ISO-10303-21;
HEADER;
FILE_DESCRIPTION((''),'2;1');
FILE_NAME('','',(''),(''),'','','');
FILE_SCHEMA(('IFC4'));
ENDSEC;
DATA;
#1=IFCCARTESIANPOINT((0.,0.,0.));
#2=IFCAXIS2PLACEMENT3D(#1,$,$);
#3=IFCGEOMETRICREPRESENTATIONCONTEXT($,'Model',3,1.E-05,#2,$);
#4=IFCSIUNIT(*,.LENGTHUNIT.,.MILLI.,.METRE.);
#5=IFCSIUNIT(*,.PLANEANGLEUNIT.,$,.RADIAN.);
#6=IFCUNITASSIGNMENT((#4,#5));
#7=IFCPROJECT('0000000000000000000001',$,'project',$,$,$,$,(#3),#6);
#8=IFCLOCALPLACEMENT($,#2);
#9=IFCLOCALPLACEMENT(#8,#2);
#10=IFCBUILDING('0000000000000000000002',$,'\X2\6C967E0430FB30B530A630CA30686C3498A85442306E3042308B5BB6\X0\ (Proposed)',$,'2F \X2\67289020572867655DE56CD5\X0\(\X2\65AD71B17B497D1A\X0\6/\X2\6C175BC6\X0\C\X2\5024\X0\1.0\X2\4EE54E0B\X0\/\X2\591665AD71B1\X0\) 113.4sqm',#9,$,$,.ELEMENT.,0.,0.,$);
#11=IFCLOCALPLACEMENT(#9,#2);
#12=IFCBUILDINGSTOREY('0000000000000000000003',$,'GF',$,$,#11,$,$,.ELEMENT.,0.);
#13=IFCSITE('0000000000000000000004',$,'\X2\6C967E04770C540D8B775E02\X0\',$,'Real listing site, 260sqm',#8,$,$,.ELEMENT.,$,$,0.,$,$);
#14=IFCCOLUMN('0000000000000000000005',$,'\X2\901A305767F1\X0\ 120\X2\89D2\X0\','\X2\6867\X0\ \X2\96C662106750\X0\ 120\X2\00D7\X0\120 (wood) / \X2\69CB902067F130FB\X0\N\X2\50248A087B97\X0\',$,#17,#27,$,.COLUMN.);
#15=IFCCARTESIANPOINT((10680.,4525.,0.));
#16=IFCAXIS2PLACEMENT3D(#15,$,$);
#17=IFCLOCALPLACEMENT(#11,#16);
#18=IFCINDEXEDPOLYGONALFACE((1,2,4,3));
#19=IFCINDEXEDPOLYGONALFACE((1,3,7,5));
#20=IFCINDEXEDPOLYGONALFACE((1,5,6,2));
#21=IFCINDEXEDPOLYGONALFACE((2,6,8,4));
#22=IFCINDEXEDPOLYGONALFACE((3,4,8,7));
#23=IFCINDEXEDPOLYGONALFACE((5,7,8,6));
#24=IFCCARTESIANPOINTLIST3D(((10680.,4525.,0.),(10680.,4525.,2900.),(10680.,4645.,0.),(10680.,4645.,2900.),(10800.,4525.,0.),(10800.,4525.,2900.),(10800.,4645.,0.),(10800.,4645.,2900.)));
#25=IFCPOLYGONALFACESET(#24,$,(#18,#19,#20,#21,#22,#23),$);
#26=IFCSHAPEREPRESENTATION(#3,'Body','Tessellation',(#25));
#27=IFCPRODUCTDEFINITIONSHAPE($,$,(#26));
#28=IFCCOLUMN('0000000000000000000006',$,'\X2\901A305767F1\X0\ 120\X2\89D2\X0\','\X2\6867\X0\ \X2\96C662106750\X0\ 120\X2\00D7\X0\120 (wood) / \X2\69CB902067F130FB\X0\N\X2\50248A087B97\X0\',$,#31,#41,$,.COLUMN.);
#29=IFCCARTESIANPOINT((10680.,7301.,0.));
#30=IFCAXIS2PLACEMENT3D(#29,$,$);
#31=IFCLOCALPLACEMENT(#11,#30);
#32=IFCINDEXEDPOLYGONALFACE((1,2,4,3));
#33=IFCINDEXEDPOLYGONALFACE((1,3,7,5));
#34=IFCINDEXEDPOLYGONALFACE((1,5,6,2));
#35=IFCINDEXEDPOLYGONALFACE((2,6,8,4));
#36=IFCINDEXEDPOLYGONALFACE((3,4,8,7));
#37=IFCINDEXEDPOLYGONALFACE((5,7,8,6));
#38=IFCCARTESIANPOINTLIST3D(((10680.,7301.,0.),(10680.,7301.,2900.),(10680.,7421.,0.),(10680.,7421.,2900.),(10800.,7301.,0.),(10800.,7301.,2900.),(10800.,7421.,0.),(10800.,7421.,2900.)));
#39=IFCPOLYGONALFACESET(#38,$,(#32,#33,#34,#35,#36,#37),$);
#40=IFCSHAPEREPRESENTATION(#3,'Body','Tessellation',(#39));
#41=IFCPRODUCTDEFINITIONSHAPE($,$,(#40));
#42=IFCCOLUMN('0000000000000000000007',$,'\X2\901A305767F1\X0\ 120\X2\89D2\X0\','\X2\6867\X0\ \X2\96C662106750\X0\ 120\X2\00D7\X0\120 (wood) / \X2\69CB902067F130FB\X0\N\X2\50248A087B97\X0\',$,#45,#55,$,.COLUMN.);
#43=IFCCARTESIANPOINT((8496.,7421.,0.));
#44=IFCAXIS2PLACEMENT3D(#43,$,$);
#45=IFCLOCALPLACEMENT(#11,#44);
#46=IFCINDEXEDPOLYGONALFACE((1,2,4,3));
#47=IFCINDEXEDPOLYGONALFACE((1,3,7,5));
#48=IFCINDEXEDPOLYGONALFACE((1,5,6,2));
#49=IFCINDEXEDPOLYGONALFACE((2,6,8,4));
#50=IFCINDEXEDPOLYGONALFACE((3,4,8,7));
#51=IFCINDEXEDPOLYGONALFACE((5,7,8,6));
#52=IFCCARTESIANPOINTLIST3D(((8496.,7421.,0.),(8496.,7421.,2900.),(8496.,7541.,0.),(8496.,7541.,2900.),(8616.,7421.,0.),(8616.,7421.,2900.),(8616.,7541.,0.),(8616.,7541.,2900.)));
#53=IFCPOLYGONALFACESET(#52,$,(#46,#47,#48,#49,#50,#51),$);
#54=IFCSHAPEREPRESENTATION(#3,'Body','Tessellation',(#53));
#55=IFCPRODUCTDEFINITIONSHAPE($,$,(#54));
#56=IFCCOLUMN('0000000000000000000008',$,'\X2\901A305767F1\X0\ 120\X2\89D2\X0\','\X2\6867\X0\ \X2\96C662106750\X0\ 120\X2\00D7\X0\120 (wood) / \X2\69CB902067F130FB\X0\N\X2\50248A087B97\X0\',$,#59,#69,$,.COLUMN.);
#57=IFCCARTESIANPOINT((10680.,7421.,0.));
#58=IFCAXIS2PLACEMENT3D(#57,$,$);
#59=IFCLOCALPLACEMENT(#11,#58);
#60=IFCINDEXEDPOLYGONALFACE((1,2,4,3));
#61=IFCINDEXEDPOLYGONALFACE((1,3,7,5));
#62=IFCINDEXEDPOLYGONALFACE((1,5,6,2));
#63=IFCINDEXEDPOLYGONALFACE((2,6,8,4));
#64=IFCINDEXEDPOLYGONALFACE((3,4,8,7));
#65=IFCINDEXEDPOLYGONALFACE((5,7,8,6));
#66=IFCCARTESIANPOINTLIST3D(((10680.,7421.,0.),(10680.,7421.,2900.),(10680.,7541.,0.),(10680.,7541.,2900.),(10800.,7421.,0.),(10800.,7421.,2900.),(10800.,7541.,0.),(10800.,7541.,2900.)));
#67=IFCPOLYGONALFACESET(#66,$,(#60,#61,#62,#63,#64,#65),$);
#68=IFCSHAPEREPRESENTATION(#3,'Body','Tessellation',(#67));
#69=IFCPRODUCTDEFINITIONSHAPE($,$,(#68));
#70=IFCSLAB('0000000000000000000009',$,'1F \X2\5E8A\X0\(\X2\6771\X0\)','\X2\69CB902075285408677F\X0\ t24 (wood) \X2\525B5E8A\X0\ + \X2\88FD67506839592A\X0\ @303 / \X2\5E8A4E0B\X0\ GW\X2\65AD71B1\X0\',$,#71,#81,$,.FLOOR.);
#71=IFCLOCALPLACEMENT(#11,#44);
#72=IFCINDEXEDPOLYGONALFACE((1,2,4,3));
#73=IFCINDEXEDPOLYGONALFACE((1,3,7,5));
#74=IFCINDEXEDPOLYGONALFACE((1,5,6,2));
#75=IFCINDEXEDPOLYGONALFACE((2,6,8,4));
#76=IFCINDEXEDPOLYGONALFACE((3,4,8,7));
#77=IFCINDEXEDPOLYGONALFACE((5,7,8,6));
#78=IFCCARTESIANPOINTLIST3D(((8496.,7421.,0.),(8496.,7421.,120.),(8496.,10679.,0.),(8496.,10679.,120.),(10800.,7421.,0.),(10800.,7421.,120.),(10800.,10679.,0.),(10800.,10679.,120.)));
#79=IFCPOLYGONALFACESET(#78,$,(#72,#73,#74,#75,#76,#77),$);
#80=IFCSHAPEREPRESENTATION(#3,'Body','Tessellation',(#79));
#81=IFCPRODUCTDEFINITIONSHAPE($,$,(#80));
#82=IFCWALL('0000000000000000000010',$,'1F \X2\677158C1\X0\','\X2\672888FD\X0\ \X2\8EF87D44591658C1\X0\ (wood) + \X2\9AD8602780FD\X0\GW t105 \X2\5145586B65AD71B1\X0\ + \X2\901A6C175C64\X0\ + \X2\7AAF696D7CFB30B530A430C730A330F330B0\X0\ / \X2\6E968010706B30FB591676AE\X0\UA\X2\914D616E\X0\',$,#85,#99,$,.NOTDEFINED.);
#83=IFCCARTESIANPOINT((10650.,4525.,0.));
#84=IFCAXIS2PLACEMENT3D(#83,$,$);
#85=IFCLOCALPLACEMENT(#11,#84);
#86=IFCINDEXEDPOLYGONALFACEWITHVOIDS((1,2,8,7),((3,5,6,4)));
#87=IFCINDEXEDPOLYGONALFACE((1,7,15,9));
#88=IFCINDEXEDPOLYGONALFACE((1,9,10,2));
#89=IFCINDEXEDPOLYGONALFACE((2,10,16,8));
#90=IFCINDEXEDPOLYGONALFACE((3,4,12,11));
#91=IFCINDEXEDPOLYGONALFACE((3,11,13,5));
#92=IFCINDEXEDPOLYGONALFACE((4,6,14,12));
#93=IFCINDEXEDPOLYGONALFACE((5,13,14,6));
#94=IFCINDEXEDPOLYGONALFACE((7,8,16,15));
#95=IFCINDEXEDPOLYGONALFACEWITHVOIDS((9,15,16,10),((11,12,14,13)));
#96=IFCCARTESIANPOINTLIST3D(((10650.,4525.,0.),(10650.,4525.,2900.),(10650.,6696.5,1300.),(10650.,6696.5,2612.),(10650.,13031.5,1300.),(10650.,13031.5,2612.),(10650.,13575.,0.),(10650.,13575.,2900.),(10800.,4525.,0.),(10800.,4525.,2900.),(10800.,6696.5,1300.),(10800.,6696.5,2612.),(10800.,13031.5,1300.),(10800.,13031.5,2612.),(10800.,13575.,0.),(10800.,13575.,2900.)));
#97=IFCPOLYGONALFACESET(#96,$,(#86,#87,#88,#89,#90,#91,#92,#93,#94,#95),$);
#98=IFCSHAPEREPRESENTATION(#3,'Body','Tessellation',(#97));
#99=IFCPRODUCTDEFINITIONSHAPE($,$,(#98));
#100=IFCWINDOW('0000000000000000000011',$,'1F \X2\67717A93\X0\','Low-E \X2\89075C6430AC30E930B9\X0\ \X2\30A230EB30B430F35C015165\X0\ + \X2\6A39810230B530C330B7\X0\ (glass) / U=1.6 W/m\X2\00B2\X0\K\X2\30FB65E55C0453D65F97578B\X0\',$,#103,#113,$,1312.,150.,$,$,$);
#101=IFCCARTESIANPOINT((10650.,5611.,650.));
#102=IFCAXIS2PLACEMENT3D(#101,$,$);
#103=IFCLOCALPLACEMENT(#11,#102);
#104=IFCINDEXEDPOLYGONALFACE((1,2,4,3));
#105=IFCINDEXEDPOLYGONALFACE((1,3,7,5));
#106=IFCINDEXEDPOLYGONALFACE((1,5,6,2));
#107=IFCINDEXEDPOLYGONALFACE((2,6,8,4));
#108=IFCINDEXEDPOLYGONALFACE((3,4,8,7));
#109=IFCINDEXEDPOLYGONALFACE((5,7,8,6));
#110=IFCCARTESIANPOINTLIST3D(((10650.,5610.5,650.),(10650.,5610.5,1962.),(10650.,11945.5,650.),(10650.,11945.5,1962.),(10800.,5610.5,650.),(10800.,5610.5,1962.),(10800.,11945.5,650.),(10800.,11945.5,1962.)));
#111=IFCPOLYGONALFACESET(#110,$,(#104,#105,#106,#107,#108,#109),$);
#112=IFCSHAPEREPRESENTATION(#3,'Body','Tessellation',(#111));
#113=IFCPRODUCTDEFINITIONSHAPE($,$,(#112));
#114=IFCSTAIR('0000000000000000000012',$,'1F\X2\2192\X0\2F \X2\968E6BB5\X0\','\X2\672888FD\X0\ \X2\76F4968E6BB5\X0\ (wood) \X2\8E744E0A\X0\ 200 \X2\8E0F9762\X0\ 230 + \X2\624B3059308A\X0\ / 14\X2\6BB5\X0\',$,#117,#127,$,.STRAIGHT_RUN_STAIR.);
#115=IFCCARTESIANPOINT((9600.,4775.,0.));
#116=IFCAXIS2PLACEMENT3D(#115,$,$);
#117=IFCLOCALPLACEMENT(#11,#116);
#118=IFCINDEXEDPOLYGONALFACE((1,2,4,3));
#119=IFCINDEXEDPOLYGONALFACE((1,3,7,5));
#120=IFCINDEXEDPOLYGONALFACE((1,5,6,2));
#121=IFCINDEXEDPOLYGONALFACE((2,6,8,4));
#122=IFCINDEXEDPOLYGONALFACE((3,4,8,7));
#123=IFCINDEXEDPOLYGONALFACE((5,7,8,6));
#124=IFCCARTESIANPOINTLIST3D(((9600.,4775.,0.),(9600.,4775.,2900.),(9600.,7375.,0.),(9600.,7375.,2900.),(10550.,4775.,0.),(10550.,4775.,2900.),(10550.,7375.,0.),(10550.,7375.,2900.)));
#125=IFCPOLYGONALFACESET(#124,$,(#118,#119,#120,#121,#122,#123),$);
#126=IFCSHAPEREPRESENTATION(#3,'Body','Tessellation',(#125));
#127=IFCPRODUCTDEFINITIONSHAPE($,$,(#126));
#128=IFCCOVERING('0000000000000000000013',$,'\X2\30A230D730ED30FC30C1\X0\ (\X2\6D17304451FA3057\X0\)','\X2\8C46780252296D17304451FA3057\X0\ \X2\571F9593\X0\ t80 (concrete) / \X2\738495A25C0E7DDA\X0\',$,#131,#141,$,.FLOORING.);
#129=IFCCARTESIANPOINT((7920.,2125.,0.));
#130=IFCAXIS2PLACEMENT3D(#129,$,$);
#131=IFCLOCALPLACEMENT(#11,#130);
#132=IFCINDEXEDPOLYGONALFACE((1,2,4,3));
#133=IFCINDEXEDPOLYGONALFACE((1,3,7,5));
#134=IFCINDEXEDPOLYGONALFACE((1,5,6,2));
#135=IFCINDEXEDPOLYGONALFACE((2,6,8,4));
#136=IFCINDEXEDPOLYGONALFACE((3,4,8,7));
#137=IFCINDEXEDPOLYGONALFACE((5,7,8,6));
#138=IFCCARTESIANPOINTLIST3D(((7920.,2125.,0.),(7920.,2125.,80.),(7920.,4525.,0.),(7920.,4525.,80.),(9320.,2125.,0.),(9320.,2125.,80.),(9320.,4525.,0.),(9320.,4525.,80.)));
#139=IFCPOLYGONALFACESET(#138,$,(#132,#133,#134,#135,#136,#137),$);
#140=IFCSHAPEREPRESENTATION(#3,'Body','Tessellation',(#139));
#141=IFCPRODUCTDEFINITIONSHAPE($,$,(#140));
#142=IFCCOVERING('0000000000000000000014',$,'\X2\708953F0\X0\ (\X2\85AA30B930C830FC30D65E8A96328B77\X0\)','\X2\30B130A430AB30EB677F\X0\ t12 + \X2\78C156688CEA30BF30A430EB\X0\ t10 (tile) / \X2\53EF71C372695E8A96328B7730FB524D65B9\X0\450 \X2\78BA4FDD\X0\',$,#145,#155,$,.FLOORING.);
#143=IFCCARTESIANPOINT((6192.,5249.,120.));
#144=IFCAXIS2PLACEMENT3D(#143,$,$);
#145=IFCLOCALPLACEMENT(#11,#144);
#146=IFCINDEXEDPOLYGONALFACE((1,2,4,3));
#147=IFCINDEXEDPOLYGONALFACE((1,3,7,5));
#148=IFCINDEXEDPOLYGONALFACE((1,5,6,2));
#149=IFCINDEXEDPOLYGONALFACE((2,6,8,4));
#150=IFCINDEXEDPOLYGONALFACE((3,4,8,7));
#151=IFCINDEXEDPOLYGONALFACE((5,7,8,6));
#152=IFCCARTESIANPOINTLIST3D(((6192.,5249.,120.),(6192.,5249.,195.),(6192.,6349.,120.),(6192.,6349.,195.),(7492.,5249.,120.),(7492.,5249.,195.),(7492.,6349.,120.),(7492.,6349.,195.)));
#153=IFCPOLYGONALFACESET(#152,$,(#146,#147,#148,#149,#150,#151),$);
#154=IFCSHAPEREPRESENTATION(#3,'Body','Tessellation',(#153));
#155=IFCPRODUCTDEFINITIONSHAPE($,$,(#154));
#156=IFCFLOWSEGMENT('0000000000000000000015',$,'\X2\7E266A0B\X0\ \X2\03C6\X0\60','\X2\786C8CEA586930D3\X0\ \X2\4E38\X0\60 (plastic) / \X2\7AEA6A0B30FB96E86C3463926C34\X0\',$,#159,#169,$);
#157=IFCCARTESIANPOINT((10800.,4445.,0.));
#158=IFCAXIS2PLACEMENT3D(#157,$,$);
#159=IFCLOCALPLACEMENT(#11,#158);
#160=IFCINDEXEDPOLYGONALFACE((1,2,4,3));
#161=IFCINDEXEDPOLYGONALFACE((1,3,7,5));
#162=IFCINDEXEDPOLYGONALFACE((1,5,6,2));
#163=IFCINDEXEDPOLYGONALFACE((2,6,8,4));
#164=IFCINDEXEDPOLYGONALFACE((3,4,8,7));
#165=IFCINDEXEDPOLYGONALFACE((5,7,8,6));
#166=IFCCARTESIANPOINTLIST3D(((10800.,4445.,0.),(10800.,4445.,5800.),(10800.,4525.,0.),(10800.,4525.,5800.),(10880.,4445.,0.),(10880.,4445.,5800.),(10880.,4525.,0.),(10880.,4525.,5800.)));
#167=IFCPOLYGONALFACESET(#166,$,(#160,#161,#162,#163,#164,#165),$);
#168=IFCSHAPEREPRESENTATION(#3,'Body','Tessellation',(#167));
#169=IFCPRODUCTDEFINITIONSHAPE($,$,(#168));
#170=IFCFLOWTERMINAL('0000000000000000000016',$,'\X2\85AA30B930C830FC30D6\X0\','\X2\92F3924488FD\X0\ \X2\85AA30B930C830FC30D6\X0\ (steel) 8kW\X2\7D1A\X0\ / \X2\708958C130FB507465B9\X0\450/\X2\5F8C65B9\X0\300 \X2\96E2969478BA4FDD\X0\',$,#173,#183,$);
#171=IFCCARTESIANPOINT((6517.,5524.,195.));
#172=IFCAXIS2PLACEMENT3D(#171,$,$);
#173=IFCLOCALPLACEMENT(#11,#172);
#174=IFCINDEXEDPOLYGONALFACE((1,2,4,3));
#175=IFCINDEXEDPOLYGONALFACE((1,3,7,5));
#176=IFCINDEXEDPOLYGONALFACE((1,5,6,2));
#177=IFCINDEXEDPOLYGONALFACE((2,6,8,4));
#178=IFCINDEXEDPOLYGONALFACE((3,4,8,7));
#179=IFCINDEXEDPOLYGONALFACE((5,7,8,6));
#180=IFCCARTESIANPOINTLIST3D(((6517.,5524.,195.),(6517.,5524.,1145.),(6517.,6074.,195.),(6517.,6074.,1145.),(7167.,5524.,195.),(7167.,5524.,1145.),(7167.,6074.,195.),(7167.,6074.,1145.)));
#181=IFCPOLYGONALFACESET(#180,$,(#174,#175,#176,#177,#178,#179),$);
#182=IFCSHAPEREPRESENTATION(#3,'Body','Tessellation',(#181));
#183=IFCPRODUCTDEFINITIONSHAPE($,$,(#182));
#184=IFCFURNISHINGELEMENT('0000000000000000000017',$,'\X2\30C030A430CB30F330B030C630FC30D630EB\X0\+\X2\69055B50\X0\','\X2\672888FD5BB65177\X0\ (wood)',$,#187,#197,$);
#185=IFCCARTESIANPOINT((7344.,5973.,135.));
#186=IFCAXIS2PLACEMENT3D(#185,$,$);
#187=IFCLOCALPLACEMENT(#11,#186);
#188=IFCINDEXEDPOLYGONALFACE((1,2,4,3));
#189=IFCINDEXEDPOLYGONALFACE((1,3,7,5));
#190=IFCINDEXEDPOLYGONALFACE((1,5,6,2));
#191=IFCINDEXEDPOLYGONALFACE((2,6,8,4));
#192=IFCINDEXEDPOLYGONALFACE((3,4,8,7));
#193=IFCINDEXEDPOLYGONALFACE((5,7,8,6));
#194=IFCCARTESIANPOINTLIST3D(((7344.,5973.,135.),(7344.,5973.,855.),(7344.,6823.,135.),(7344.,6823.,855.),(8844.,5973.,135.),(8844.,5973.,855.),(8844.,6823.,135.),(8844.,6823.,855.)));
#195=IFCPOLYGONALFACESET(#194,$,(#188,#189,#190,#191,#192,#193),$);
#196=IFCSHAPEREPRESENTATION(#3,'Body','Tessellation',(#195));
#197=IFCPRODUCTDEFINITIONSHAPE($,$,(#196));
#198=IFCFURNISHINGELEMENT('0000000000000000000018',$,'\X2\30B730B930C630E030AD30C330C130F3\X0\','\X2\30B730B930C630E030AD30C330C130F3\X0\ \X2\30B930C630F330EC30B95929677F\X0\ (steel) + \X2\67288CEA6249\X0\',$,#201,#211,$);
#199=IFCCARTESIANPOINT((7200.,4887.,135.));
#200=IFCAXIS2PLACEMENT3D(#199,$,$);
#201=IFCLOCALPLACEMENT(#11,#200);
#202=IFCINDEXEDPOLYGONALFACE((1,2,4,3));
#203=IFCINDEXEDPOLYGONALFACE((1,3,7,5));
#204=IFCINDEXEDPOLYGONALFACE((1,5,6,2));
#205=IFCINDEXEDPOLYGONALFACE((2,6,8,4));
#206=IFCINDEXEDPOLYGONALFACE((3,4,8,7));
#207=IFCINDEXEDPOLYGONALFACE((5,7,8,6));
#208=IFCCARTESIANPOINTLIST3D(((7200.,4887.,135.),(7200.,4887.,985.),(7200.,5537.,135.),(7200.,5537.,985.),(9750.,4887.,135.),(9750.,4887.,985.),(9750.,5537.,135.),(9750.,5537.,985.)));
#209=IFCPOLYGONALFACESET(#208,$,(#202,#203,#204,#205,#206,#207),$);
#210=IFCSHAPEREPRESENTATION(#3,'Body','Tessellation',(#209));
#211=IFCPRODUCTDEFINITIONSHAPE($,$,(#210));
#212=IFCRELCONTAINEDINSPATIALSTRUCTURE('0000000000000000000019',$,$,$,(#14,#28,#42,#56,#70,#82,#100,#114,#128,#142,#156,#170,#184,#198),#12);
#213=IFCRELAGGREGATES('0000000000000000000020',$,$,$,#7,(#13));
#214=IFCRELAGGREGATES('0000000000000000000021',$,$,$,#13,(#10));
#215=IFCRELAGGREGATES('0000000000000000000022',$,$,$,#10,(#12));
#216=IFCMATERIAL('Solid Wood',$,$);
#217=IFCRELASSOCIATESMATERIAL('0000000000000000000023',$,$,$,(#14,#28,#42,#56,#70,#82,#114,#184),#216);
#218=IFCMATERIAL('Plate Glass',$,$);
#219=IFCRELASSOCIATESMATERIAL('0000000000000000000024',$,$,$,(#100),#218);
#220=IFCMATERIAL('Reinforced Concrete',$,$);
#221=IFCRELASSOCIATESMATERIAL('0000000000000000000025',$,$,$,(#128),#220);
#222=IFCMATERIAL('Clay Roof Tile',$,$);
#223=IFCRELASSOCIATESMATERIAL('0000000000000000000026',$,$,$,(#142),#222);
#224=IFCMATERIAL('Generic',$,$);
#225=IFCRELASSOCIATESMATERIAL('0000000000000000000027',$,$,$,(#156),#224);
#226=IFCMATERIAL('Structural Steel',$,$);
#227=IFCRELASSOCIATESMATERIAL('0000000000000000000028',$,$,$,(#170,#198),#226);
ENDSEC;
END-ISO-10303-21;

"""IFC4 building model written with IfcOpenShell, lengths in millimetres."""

from ifc_helpers import new_model, si_unit, frame, frame_2d, origin, place, context, project, spatial, rectangle, extrude, material, element, fill, save


model = new_model("IFC4")

# Units and contexts
model_context = context("Model", 3, precision=1e-05, world=origin())
ifc_project = project(units=[si_unit("LENGTHUNIT", "METRE", prefix="MILLI"), si_unit("PLANEANGLEUNIT", "RADIAN")], contexts=[model_context])

# Site, building, storey
site_placement = place(None, origin())
site = spatial("IfcSite", under=ifc_project, at=site_placement, Name="沖縄県名護市", ObjectType="Real listing site, 260sqm", CompositionType="ELEMENT", RefElevation=0.0)
building_placement = place(site_placement, origin())
building = spatial("IfcBuilding", under=site, at=building_placement, Name="沖縄・サウナと水風呂のある家 (Proposed)", ObjectType="2F 木造在来工法(断熱等級6/気密C値1.0以下/外断熱) 113.4sqm", CompositionType="ELEMENT", ElevationOfRefHeight=0.0, ElevationOfTerrain=0.0)
storey_placement = place(building_placement, origin())
storey = spatial("IfcBuildingStorey", under=building, at=storey_placement, Name="GF", CompositionType="ELEMENT", Elevation=0.0)

# Columns
ifc_material_1 = material(Name="Solid Wood")
column_1_placement = place(storey_placement, frame((10680.0, 4525.0, 0.0)))
element("IfcColumn", 1, at=column_1_placement, inside=storey, material=ifc_material_1, Name="通し柱 120角", Description="桧 集成材 120×120 (wood) / 構造柱・N値計算", PredefinedType="COLUMN", context=model_context, shape_type="SweptSolid", body=[
    extrude(rectangle(XDim=120.0, YDim=120.0, at=frame_2d((60.0, 60.0))), frame((10680.0, 4525.0, 0.0)), (0.0, 0.0, 1.0), 2900.0),
])
column_2_placement = place(storey_placement, frame((10680.0, 7301.0, 0.0)))
element("IfcColumn", 2, at=column_2_placement, inside=storey, material=ifc_material_1, Name="通し柱 120角", Description="桧 集成材 120×120 (wood) / 構造柱・N値計算", PredefinedType="COLUMN", context=model_context, shape_type="SweptSolid", body=[
    extrude(rectangle(XDim=120.0, YDim=120.0, at=frame_2d((60.0, 60.0))), frame((10680.0, 7301.0, 0.0)), (0.0, 0.0, 1.0), 2900.0),
])
column_3_placement = place(storey_placement, frame((8496.0, 7421.0, 0.0)))
element("IfcColumn", 3, at=column_3_placement, inside=storey, material=ifc_material_1, Name="通し柱 120角", Description="桧 集成材 120×120 (wood) / 構造柱・N値計算", PredefinedType="COLUMN", context=model_context, shape_type="SweptSolid", body=[
    extrude(rectangle(XDim=120.0, YDim=120.0, at=frame_2d((60.0, 60.0))), frame((8496.0, 7421.0, 0.0)), (0.0, 0.0, 1.0), 2900.0),
])
column_4_placement = place(storey_placement, frame((10680.0, 7421.0, 0.0)))
element("IfcColumn", 4, at=column_4_placement, inside=storey, material=ifc_material_1, Name="通し柱 120角", Description="桧 集成材 120×120 (wood) / 構造柱・N値計算", PredefinedType="COLUMN", context=model_context, shape_type="SweptSolid", body=[
    extrude(rectangle(XDim=120.0, YDim=120.0, at=frame_2d((60.0, 60.0))), frame((10680.0, 7421.0, 0.0)), (0.0, 0.0, 1.0), 2900.0),
])

# Slab
slab_placement = place(storey_placement, frame((8496.0, 7421.0, 0.0)))
element("IfcSlab", 5, at=slab_placement, inside=storey, material=ifc_material_1, Name="1F 床(東)", Description="構造用合板 t24 (wood) 剛床 + 製材根太 @303 / 床下 GW断熱", PredefinedType="FLOOR", context=model_context, shape_type="SweptSolid", body=[
    extrude(rectangle(XDim=2304.0, YDim=3258.0, at=frame_2d((1152.0, 1629.0))), frame((8496.0, 7421.0, 0.0)), (0.0, 0.0, 1.0), 120.0),
])

# Wall, opening, window
wall_1_placement = place(storey_placement, frame((10650.0, 4525.0, 0.0)))
wall_1 = element("IfcWall", 6, at=wall_1_placement, inside=storey, material=ifc_material_1, Name="1F 東壁", Description="木製 軸組外壁 (wood) + 高性能GW t105 充填断熱 + 通気層 + 窯業系サイディング / 準耐火・外皮UA配慮", PredefinedType="NOTDEFINED", context=model_context, shape_type="SweptSolid", body=[
    extrude(rectangle(XDim=150.0, YDim=9050.0, at=frame_2d((75.0, 4525.0))), frame((10650.0, 4525.0, 0.0)), (0.0, 0.0, 1.0), 2900.0),
])
opening_placement = place(storey_placement, frame((10650.0, 5611.0, 650.0)))
opening = element("IfcOpeningElement", 7, at=opening_placement, cuts=wall_1, PredefinedType="NOTDEFINED", context=model_context, shape_type="SweptSolid", body=[
    extrude(rectangle(XDim=150.0, YDim=6335.0, at=frame_2d((75.0, 3167.0))), frame((10650.0, 5611.0, 650.0)), (0.0, 0.0, 1.0), 1312.0),
])
ifc_material_2 = material(Name="Plate Glass")
window_placement = place(storey_placement, frame((10650.0, 5611.0, 650.0)))
window = element("IfcWindow", 8, at=window_placement, inside=storey, material=ifc_material_2, Name="1F 東窓", Description="Low-E 複層ガラス アルゴン封入 + 樹脂サッシ (glass) / U=1.6 W/m²K・日射取得型", OverallHeight=1312.0, OverallWidth=150.0, context=model_context, shape_type="SweptSolid", body=[
    extrude(rectangle(XDim=150.0, YDim=6335.0, at=frame_2d((75.0, 3167.0))), frame((10650.0, 5611.0, 650.0)), (0.0, 0.0, 1.0), 1312.0),
])
fill(opening, window)

# Stair
stair_placement = place(storey_placement, frame((9600.0, 4775.0, 0.0)))
element("IfcStair", 9, at=stair_placement, inside=storey, material=ifc_material_1, Name="1F→2F 階段", Description="木製 直階段 (wood) 蹴上 200 踏面 230 + 手すり / 14段", PredefinedType="STRAIGHT_RUN_STAIR", context=model_context, shape_type="SweptSolid", body=[
    extrude(rectangle(XDim=950.0, YDim=2600.0, at=frame_2d((475.0, 1300.0))), frame((9600.0, 4775.0, 0.0)), (0.0, 0.0, 1.0), 2900.0),
])

# Coverings
ifc_material_3 = material(Name="Reinforced Concrete")
covering_1_placement = place(storey_placement, frame((7920.0, 2125.0, 0.0)))
element("IfcCovering", 10, at=covering_1_placement, inside=storey, material=ifc_material_3, Name="アプローチ (洗い出し)", Description="豆砂利洗い出し 土間 t80 (concrete) / 玄関導線", PredefinedType="FLOORING", context=model_context, shape_type="SweptSolid", body=[
    extrude(rectangle(XDim=1400.0, YDim=2400.0, at=frame_2d((700.0, 1200.0))), frame((7920.0, 2125.0, 0.0)), (0.0, 0.0, 1.0), 80.0),
])
ifc_material_4 = material(Name="Clay Roof Tile")
covering_2_placement = place(storey_placement, frame((6192.0, 5249.0, 120.0)))
element("IfcCovering", 11, at=covering_2_placement, inside=storey, material=ifc_material_4, Name="炉台 (薪ストーブ床防護)", Description="ケイカル板 t12 + 磁器質タイル t10 (tile) / 可燃物床防護・前方450 確保", PredefinedType="FLOORING", context=model_context, shape_type="SweptSolid", body=[
    extrude(rectangle(XDim=1300.0, YDim=1100.0, at=frame_2d((650.0, 550.0))), frame((6192.0, 5249.0, 120.0)), (0.0, 0.0, 1.0), 75.0),
])

# Flow segment
ifc_material_5 = material(Name="Generic")
flow_segment_placement = place(storey_placement, frame((10800.0, 4445.0, 0.0)))
element("IfcFlowSegment", 12, at=flow_segment_placement, inside=storey, material=ifc_material_5, Name="縦樋 φ60", Description="硬質塩ビ 丸60 (plastic) / 竪樋・雨水排水", context=model_context, shape_type="SweptSolid", body=[
    extrude(rectangle(XDim=80.0, YDim=80.0, at=frame_2d((40.0, 40.0))), frame((10800.0, 4445.0, 0.0)), (0.0, 0.0, 1.0), 5800.0),
])

# Flow terminal
ifc_material_6 = material(Name="Structural Steel")
flow_terminal_placement = place(storey_placement, frame((6517.0, 5524.0, 195.0)))
element("IfcFlowTerminal", 13, at=flow_terminal_placement, inside=storey, material=ifc_material_6, Name="薪ストーブ", Description="鋳鉄製 薪ストーブ (steel) 8kW級 / 炉壁・側方450/後方300 離隔確保", context=model_context, shape_type="SweptSolid", body=[
    extrude(rectangle(XDim=650.0, YDim=550.0, at=frame_2d((325.0, 275.0))), frame((6517.0, 5524.0, 195.0)), (0.0, 0.0, 1.0), 950.0),
])

# Furnishing elements
furnishing_1_placement = place(storey_placement, frame((7344.0, 5973.0, 135.0)))
element("IfcFurnishingElement", 14, at=furnishing_1_placement, inside=storey, material=ifc_material_1, Name="ダイニングテーブル+椅子", Description="木製家具 (wood)", context=model_context, shape_type="SweptSolid", body=[
    extrude(rectangle(XDim=1500.0, YDim=850.0, at=frame_2d((750.0, 425.0))), frame((7344.0, 5973.0, 135.0)), (0.0, 0.0, 1.0), 720.0),
])
furnishing_2_placement = place(storey_placement, frame((7200.0, 4887.0, 135.0)))
element("IfcFurnishingElement", 15, at=furnishing_2_placement, inside=storey, material=ifc_material_6, Name="システムキッチン", Description="システムキッチン ステンレス天板 (steel) + 木質扉", context=model_context, shape_type="SweptSolid", body=[
    extrude(rectangle(XDim=2550.0, YDim=650.0, at=frame_2d((1275.0, 325.0))), frame((7200.0, 4887.0, 135.0)), (0.0, 0.0, 1.0), 850.0),
])

save(model, "model.ifc")
